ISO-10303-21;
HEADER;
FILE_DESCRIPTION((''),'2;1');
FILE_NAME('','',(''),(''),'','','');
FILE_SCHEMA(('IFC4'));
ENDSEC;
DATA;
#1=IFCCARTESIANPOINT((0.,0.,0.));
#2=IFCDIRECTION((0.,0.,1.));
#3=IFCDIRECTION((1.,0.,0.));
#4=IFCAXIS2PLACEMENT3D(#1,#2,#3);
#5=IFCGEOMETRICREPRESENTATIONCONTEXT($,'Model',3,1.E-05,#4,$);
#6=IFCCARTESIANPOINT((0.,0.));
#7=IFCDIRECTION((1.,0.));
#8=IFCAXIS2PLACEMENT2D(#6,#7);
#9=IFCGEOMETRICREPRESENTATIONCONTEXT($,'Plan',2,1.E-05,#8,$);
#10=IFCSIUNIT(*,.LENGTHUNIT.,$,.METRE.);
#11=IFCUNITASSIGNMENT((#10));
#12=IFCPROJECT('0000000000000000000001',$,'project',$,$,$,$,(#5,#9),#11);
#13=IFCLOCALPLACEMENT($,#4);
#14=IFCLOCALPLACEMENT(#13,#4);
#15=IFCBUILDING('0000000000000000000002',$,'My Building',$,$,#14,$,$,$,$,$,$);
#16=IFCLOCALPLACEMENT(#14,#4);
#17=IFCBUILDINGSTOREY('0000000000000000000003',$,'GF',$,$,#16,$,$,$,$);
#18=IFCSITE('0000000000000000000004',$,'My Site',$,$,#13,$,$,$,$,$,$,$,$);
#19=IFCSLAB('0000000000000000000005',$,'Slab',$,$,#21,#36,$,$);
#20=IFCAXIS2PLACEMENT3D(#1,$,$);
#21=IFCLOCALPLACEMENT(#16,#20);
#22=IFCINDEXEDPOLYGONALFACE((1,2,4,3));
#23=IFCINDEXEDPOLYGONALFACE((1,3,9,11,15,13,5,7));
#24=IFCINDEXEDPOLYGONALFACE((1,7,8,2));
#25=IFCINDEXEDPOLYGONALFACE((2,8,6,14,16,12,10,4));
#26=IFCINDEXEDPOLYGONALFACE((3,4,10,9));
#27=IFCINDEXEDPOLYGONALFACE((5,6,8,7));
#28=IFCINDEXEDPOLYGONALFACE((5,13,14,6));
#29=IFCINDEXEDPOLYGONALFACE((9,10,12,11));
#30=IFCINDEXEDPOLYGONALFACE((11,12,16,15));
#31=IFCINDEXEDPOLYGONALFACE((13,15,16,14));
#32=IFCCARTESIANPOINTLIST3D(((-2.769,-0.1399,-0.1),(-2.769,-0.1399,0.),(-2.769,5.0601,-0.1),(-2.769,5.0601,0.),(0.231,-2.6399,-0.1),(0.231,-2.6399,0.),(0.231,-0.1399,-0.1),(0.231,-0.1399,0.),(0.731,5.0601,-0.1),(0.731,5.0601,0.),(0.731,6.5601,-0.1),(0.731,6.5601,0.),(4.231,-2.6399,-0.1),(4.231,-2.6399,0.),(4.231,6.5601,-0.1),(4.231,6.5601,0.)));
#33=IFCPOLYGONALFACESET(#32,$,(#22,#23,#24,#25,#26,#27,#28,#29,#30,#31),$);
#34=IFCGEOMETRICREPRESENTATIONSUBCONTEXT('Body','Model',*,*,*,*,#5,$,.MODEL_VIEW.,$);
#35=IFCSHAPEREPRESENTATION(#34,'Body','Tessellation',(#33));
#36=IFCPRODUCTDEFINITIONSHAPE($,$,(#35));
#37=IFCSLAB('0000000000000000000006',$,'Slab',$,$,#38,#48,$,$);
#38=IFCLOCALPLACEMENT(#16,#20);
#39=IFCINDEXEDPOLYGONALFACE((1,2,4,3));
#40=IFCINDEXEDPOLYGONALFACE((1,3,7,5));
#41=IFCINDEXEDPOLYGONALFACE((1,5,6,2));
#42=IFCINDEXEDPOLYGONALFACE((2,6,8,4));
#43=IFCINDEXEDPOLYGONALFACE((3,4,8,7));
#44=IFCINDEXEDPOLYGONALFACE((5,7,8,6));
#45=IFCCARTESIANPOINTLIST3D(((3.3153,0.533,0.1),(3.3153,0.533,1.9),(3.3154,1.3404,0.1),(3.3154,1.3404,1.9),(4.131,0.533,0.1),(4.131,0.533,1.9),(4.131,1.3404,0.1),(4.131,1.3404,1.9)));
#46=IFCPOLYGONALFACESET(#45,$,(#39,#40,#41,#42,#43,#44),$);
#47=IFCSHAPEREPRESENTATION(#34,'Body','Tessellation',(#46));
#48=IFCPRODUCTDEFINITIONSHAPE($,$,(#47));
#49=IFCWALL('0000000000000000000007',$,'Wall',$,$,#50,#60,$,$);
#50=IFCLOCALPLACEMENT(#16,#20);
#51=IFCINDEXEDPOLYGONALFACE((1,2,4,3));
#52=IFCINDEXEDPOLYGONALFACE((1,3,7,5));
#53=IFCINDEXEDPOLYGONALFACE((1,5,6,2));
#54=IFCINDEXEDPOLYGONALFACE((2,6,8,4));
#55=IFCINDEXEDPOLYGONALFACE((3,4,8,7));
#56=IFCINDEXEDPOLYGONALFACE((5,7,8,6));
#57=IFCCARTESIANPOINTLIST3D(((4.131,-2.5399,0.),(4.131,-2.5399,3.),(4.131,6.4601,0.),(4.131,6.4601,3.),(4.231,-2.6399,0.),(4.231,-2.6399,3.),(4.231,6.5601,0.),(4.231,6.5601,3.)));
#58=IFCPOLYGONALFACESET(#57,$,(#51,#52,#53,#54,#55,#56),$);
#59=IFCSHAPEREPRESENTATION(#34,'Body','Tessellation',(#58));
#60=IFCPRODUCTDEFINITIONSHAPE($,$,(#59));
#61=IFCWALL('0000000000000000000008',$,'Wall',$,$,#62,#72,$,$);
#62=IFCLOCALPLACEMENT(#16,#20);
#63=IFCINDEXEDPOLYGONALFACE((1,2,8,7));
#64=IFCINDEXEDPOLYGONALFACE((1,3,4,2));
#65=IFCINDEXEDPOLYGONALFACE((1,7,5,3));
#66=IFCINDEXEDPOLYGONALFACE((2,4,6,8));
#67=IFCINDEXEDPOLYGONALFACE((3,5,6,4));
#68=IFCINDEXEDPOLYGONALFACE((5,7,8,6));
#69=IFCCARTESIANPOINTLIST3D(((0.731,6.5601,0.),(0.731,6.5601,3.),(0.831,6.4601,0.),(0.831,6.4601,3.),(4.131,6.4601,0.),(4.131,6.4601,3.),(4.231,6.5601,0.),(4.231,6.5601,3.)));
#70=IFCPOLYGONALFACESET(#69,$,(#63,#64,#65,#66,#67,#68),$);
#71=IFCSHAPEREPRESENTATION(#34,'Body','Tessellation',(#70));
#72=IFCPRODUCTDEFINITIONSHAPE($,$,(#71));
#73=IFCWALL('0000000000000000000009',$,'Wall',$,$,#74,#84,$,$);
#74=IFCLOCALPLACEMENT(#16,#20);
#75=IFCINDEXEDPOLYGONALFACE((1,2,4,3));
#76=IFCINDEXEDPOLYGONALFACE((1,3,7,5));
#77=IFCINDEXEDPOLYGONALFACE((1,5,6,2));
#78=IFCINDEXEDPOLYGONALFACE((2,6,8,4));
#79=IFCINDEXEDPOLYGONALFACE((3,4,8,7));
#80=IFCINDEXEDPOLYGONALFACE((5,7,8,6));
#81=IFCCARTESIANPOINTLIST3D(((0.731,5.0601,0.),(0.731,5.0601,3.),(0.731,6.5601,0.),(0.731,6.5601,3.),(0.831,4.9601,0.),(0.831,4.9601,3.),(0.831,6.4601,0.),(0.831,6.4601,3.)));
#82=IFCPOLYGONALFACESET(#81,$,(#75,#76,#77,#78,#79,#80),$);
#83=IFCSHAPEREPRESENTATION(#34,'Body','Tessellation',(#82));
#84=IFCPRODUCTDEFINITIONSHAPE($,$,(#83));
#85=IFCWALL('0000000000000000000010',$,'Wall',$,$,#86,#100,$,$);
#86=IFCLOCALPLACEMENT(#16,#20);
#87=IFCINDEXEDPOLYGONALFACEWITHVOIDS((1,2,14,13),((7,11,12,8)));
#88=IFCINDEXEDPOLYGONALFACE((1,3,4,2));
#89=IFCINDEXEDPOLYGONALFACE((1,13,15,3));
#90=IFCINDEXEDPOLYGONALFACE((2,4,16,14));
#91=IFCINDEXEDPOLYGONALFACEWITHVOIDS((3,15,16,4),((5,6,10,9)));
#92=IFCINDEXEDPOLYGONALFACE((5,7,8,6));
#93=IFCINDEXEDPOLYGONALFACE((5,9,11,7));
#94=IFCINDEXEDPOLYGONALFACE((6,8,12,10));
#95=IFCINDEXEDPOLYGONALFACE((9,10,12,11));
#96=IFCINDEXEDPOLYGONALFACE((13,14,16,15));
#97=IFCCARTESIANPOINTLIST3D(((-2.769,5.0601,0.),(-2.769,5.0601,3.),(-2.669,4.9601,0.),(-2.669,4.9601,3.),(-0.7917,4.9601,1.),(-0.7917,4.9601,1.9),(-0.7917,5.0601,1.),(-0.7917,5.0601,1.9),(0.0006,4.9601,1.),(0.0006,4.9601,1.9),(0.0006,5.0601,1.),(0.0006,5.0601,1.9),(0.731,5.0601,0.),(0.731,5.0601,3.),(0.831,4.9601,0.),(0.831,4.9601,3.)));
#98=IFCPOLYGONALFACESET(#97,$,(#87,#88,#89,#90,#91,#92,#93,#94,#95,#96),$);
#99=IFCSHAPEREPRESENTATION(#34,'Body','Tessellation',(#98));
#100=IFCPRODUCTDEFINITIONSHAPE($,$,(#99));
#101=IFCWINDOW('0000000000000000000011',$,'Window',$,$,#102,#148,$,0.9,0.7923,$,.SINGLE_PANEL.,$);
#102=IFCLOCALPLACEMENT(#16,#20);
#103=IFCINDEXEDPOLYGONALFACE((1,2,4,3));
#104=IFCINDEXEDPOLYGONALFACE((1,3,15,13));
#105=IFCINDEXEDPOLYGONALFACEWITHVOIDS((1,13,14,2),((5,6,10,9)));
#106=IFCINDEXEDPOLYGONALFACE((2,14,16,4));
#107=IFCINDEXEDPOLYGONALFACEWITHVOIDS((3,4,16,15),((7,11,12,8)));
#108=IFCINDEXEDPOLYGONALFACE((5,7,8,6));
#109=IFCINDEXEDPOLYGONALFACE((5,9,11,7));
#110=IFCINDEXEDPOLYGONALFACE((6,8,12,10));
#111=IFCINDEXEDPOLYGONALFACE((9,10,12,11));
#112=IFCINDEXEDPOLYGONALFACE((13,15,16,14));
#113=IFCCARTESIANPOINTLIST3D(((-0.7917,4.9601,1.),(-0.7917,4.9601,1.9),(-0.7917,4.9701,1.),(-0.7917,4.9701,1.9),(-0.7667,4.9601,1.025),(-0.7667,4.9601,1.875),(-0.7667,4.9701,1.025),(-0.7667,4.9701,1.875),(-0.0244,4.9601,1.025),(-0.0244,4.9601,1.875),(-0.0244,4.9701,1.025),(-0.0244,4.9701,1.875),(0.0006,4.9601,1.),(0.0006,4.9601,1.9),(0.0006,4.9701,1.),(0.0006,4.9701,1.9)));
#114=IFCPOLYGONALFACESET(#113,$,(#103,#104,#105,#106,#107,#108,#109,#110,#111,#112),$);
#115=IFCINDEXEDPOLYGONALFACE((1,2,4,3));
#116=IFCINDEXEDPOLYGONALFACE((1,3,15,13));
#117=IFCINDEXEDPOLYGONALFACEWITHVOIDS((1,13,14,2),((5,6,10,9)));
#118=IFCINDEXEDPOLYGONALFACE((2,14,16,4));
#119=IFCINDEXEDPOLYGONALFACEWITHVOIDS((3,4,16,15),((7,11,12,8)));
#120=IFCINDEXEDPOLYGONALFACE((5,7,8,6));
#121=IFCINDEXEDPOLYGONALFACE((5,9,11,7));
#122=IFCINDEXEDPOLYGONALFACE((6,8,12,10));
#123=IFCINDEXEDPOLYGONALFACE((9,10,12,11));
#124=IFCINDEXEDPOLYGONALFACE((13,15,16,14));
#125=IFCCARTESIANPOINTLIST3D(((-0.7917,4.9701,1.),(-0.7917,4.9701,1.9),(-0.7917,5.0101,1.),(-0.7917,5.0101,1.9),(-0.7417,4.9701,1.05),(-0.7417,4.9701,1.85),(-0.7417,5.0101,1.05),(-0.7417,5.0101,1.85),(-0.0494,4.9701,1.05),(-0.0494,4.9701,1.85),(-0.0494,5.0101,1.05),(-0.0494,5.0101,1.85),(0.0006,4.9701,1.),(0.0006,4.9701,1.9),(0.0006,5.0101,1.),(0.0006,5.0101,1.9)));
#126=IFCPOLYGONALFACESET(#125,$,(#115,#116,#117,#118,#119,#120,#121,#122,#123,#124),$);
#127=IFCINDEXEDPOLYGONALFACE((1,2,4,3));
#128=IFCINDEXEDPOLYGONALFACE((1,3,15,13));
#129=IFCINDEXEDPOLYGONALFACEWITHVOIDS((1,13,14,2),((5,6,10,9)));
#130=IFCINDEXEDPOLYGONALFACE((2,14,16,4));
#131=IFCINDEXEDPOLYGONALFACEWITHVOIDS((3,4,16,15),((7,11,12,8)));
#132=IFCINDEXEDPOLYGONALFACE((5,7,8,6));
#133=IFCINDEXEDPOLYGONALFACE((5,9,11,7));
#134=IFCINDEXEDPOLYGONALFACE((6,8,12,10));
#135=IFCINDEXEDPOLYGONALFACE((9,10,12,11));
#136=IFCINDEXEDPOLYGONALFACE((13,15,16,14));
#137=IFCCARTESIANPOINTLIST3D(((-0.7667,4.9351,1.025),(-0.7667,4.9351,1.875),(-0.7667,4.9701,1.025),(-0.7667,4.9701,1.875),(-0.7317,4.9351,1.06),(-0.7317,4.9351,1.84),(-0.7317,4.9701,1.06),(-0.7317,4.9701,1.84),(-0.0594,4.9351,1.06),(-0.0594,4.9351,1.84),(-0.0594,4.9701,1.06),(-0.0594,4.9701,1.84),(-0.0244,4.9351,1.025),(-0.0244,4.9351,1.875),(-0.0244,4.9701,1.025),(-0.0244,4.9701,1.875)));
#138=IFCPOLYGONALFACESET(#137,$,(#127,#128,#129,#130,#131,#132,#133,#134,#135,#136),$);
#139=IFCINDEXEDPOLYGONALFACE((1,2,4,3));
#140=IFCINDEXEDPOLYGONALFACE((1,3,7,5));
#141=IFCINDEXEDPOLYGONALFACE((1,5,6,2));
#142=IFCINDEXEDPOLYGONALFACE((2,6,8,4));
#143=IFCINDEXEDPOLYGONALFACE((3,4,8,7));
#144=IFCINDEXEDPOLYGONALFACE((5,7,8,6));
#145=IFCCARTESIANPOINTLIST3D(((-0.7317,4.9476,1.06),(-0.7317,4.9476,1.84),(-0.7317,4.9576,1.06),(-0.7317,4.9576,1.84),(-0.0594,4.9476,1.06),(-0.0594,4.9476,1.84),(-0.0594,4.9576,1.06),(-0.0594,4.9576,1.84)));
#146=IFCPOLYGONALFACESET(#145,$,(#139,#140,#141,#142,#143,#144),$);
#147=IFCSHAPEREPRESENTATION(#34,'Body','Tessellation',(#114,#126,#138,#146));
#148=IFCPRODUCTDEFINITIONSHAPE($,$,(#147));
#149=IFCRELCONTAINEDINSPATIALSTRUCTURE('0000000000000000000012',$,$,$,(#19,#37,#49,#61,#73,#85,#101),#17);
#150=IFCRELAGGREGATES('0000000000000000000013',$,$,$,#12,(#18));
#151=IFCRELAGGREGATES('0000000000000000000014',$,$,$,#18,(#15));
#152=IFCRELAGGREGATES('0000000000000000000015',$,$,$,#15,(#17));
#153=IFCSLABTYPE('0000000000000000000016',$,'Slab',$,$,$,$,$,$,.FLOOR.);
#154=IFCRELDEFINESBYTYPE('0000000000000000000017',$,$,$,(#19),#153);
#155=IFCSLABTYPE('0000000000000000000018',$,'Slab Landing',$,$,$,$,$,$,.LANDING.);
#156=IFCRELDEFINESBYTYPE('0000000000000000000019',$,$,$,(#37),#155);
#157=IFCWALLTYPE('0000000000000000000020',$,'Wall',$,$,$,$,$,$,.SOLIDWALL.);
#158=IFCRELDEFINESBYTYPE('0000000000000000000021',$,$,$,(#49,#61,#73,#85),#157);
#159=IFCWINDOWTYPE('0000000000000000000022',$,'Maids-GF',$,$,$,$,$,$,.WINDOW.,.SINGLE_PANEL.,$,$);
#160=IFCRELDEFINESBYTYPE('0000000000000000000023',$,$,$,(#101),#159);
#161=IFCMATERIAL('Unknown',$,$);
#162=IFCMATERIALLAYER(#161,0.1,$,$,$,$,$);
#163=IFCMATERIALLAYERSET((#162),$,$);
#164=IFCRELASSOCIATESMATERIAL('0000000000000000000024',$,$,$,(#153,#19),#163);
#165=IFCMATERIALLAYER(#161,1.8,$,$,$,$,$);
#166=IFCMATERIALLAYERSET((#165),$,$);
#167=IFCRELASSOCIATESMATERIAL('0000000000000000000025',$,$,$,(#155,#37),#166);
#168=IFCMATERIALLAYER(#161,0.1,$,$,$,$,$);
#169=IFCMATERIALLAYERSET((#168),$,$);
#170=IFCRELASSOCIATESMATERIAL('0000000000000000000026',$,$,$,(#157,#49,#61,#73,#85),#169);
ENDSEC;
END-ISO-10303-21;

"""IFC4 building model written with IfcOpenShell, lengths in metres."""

from ifc_helpers import new_model, entity, si_unit, frame, origin_with_axes, origin_2d_with_axis, place, context, subcontext, project, spatial, line, indexed_curve, outline, extrude, shape, source, transform, mapped, material, layer, layer_set, layer_usage, type_object, type_shapes, element, fill, save


model = new_model("IFC4")

# Units and contexts
model_context = context("Model", 3, precision=1e-05, world=origin_with_axes())
plan_context = context("Plan", 2, precision=1e-05, world=origin_2d_with_axis())
body_context_1 = subcontext(model_context, "Body", "Model", "MODEL_VIEW")
body_context_2 = subcontext(plan_context, "Body", "Plan", "PLAN_VIEW")
ifc_project = project(units=[si_unit("LENGTHUNIT", "METRE")], contexts=[model_context, plan_context])

# Site, building, storey
site_placement = place(None, origin_with_axes())
site = spatial("IfcSite", under=ifc_project, at=site_placement, Name="My Site")
building_placement = place(site_placement, origin_with_axes())
building = spatial("IfcBuilding", under=site, at=building_placement, Name="My Building")
storey_placement = place(building_placement, origin_with_axes())
storey = spatial("IfcBuildingStorey", under=building, at=storey_placement, Name="GF")

# Slabs
ifc_material_1 = material(Name="Unknown")
ifc_layer_1 = layer(ifc_material_1, 0.1)
ifc_layer_set_1 = layer_set([ifc_layer_1])
ifc_layer_usage_1 = layer_usage(ifc_layer_set_1, "AXIS3", "POSITIVE", -0.1)
slab_type_1 = type_object("IfcSlabType", Name="Slab", PredefinedType="FLOOR", material=ifc_layer_set_1)
slab_1_placement = place(storey_placement, frame((4.231, 6.5601, 0.0), z_axis=(0.0, 0.0, 1.0), x_axis=(1.0, 0.0, 0.0)))
element("IfcSlab", 1, at=slab_1_placement, inside=storey, type_object=slab_type_1, material=ifc_layer_usage_1, Name="Slab", context=body_context_1, shape_type="SweptSolid", body=[
    extrude(outline(indexed_curve([(0.0, 0.0), (-3.5, 0.0), (-3.5, -1.5), (-7.0, -1.5), (-7.0, -6.7), (-4.0, -6.7), (-4.0, -9.2), (0.0, -9.2), (0.0, 0.0)])), frame((0.0, 0.0, -0.1), z_axis=(0.0, 0.0, 1.0), x_axis=(1.0, 0.0, 0.0)), (0.0, 0.0, 1.0), 0.1),
])
ifc_layer_2 = layer(ifc_material_1, 1.8)
ifc_layer_set_2 = layer_set([ifc_layer_2])
ifc_layer_usage_2 = layer_usage(ifc_layer_set_2, "AXIS3", "POSITIVE", -0.1)
slab_type_2 = type_object("IfcSlabType", Name="Slab Landing", PredefinedType="LANDING", material=ifc_layer_set_2)
slab_2_placement = place(storey_placement, frame((3.3153, 0.533, 0.2), z_axis=(0.0, 0.0, 1.0), x_axis=(1.0, 0.0, 0.0)))
element("IfcSlab", 2, at=slab_2_placement, inside=storey, type_object=slab_type_2, material=ifc_layer_usage_2, Name="Slab", context=body_context_1, shape_type="SweptSolid", body=[
    extrude(outline(indexed_curve([(0.0, 0.0), (0.8156, 0.0), (0.8156, 0.8074), (0.0, 0.8074), (0.0, 0.0)])), frame((0.0, 0.0, -0.1), z_axis=(0.0, 0.0, 1.0), x_axis=(1.0, 0.0, 0.0)), (0.0, 0.0, 1.0), 1.8),
])

# Shared definitions
ifc_layer_3 = layer(ifc_material_1, 0.1)
ifc_layer_set_3 = layer_set([ifc_layer_3])
wall_type = type_object("IfcWallType", Name="Wall", PredefinedType="SOLIDWALL", material=ifc_layer_set_3)

# Walls
ifc_layer_usage_3 = layer_usage(ifc_layer_set_3, "AXIS2", "POSITIVE", 0.0)
wall_1_placement = place(storey_placement, frame((4.231, -2.6399, 0.0), z_axis=(0.0, 0.0, 1.0), x_axis=(0.0, 1.0, 0.0)))
element("IfcWall", 3, at=wall_1_placement, inside=storey, type_object=wall_type, material=ifc_layer_usage_3, Name="Wall", context=body_context_1, shape_type="SweptSolid", body=[
    extrude(outline(indexed_curve([(0.0, 0.0), (0.1, 0.1), (9.1, 0.1), (9.2, 0.0)], segments=[line(1, 2, 3, 4, 1)])), origin_with_axes(), (0.0, 0.0, 1.0), 3.0),
])
ifc_layer_usage_4 = layer_usage(ifc_layer_set_3, "AXIS2", "POSITIVE", 0.0)
wall_2_placement = place(storey_placement, frame((4.231, 6.5601, 0.0), z_axis=(0.0, 0.0, 1.0), x_axis=(-1.0, 0.0, 0.0)))
element("IfcWall", 4, at=wall_2_placement, inside=storey, type_object=wall_type, material=ifc_layer_usage_4, Name="Wall", context=body_context_1, shape_type="SweptSolid", body=[
    extrude(outline(indexed_curve([(0.0, 0.0), (0.1, 0.1), (3.4, 0.1), (3.5, 0.0)], segments=[line(1, 2, 3, 4, 1)])), origin_with_axes(), (0.0, 0.0, 1.0), 3.0),
])
ifc_layer_usage_5 = layer_usage(ifc_layer_set_3, "AXIS2", "POSITIVE", 0.0)
wall_3_placement = place(storey_placement, frame((0.731, 6.5601, 0.0), z_axis=(0.0, 0.0, 1.0), x_axis=(0.0, -1.0, 0.0)))
element("IfcWall", 5, at=wall_3_placement, inside=storey, type_object=wall_type, material=ifc_layer_usage_5, Name="Wall", context=body_context_1, shape_type="SweptSolid", body=[
    extrude(outline(indexed_curve([(0.0, 0.0), (0.1, 0.1), (1.6, 0.1), (1.5, 0.0)], segments=[line(1, 2, 3, 4, 1)])), origin_with_axes(), (0.0, 0.0, 1.0), 3.0),
])

# Wall, opening, window
ifc_layer_usage_6 = layer_usage(ifc_layer_set_3, "AXIS2", "POSITIVE", 0.0)
wall_4_placement = place(storey_placement, frame((0.731, 5.0601, 0.0), z_axis=(0.0, 0.0, 1.0), x_axis=(-1.0, 0.0, 0.0)))
wall_4 = element("IfcWall", 6, at=wall_4_placement, inside=storey, type_object=wall_type, material=ifc_layer_usage_6, Name="Wall", context=body_context_1, shape_type="SweptSolid", body=[
    extrude(outline(indexed_curve([(0.0, 0.0), (-0.1, 0.1), (3.4, 0.1), (3.5, 0.0)], segments=[line(1, 2, 3, 4, 1)])), origin_with_axes(), (0.0, 0.0, 1.0), 3.0),
])
shared_shape_1 = source(origin_with_axes(), body_context_1, "Body", "SweptSolid", [
    extrude(outline(indexed_curve([(0.0, 0.0), (0.7923, 0.0), (0.7923, 0.9), (0.0, 0.9)], segments=[line(1, 2, 3, 4, 1)])), frame((0.0, -0.6, 0.0), z_axis=(0.0, -1.0, 0.0), x_axis=(1.0, 0.0, 0.0)), (0.0, 0.0, -1.0), 1.2),
])
opening_1_placement = place(wall_4_placement, frame((0.7304, 0.0, 1.0), z_axis=(0.0, 0.0, 1.0), x_axis=(1.0, 0.0, 0.0)))
opening_1 = element("IfcOpeningElement", 7, at=opening_1_placement, cuts=wall_4, PredefinedType="OPENING", context=body_context_1, shape_type="MappedRepresentation", body=[
    mapped(shared_shape_1, transform((0.0, 0.0, 0.0), x_axis=(1.0, 0.0, 0.0), y_axis=(0.0, 1.0, 0.0), z_axis=(0.0, 0.0, 1.0), scale=1.0)),
])
window_type_1 = type_object("IfcWindowType", Name="Maids-GF", PartitioningType="SINGLE_PANEL", PredefinedType="WINDOW")
shared_shape_2 = source(origin_with_axes(), body_context_1, "Body", "SweptSolid", [
    extrude(outline(indexed_curve([(0.0, 0.0), (0.7923, 0.0), (0.7923, 0.9), (0.0, 0.9)], segments=[line(1, 2, 3, 4, 1)]), holes=[indexed_curve([(0.025, 0.025), (0.7673, 0.025), (0.7673, 0.875), (0.025, 0.875)], segments=[line(1, 2, 3, 4, 1)])]), frame((0.0, 0.09, 0.0), z_axis=(0.0, -1.0, 0.0), x_axis=(1.0, 0.0, 0.0)), (0.0, 0.0, -1.0), 0.01),
    extrude(outline(indexed_curve([(0.0, 0.0), (0.7923, 0.0), (0.7923, 0.9), (0.0, 0.9)], segments=[line(1, 2, 3, 4, 1)]), holes=[indexed_curve([(0.05, 0.05), (0.7423, 0.05), (0.7423, 0.85), (0.05, 0.85)], segments=[line(1, 2, 3, 4, 1)])]), frame((0.0, 0.05, 0.0), z_axis=(0.0, -1.0, 0.0), x_axis=(1.0, 0.0, 0.0)), (0.0, 0.0, -1.0), 0.04),
    extrude(outline(indexed_curve([(0.0, 0.0), (0.7423, 0.0), (0.7423, 0.85), (0.0, 0.85)], segments=[line(1, 2, 3, 4, 1)]), holes=[indexed_curve([(0.035, 0.035), (0.7073, 0.035), (0.7073, 0.815), (0.035, 0.815)], segments=[line(1, 2, 3, 4, 1)])]), frame((0.025, 0.09, 0.025), z_axis=(0.0, -1.0, 0.0), x_axis=(1.0, 0.0, 0.0)), (0.0, 0.0, -1.0), 0.035),
    extrude(outline(indexed_curve([(0.035, 0.035), (0.7073, 0.035), (0.7073, 0.815), (0.035, 0.815)], segments=[line(1, 2, 3, 4, 1)])), frame((0.025, 0.1025, 0.025), z_axis=(0.0, -1.0, 0.0), x_axis=(1.0, 0.0, 0.0)), (0.0, 0.0, -1.0), 0.01),
])
shared_shape_3 = source(origin_with_axes(), body_context_2, "Body", "Curve2D", [
    entity("IfcIndexedPolyCurve", entity("IfcCartesianPointList2D", [[0.05, 0.05], [0.7423, 0.05]])),
    entity("IfcIndexedPolyCurve", entity("IfcCartesianPointList2D", [[0.0, 0.1], [0.025, 0.1], [0.025, 0.09], [0.05, 0.09], [0.05, 0.05], [0.0, 0.05]]), [entity("IfcLineIndex", [1, 2, 3, 4, 5, 6, 1])]),
    entity("IfcIndexedPolyCurve", entity("IfcCartesianPointList2D", [[0.7923, 0.1], [0.7673, 0.1], [0.7673, 0.09], [0.7423, 0.09], [0.7423, 0.05], [0.7923, 0.05]]), [entity("IfcLineIndex", [1, 2, 3, 4, 5, 6, 1])]),
    entity("IfcIndexedPolyCurve", entity("IfcCartesianPointList2D", [[0.025, 0.09], [0.06, 0.09], [0.06, 0.125], [0.025, 0.125]]), [entity("IfcLineIndex", [1, 2, 3, 4, 1])]),
    entity("IfcIndexedPolyCurve", entity("IfcCartesianPointList2D", [[0.7673, 0.09], [0.7323, 0.09], [0.7323, 0.125], [0.7673, 0.125]]), [entity("IfcLineIndex", [1, 2, 3, 4, 1])]),
    entity("IfcIndexedPolyCurve", entity("IfcCartesianPointList2D", [[0.06, 0.09], [0.7323, 0.09]])),
    entity("IfcIndexedPolyCurve", entity("IfcCartesianPointList2D", [[0.06, 0.125], [0.7323, 0.125]])),
    entity("IfcIndexedPolyCurve", entity("IfcCartesianPointList2D", [[0.06, 0.1075], [0.7323, 0.1075]])),
])
type_shapes(window_type_1, [shared_shape_2, shared_shape_3])
window_1_placement = place(opening_1_placement, frame((0.0, 0.0, 0.0), z_axis=(0.0, 0.0, 1.0), x_axis=(1.0, 0.0, 0.0)))
window_1 = element("IfcWindow", 8, at=window_1_placement, inside=storey, type_object=window_type_1, Name="Window", OverallHeight=0.9, OverallWidth=0.7923, PartitioningType="SINGLE_PANEL", shapes=[
    shape(body_context_1, "Body", "MappedRepresentation", [mapped(shared_shape_2, transform((0.0, 0.0, 0.0), x_axis=(1.0, 0.0, 0.0), y_axis=(0.0, 1.0, 0.0), z_axis=(0.0, 0.0, 1.0), scale=1.0))]),
    shape(body_context_2, "Body", "MappedRepresentation", [mapped(shared_shape_3, transform((0.0, 0.0, 0.0), x_axis=(1.0, 0.0, 0.0), y_axis=(0.0, 1.0, 0.0), z_axis=(0.0, 0.0, 1.0), scale=1.0))]),
])
fill(opening_1, window_1)

save(model, "model.ifc")
